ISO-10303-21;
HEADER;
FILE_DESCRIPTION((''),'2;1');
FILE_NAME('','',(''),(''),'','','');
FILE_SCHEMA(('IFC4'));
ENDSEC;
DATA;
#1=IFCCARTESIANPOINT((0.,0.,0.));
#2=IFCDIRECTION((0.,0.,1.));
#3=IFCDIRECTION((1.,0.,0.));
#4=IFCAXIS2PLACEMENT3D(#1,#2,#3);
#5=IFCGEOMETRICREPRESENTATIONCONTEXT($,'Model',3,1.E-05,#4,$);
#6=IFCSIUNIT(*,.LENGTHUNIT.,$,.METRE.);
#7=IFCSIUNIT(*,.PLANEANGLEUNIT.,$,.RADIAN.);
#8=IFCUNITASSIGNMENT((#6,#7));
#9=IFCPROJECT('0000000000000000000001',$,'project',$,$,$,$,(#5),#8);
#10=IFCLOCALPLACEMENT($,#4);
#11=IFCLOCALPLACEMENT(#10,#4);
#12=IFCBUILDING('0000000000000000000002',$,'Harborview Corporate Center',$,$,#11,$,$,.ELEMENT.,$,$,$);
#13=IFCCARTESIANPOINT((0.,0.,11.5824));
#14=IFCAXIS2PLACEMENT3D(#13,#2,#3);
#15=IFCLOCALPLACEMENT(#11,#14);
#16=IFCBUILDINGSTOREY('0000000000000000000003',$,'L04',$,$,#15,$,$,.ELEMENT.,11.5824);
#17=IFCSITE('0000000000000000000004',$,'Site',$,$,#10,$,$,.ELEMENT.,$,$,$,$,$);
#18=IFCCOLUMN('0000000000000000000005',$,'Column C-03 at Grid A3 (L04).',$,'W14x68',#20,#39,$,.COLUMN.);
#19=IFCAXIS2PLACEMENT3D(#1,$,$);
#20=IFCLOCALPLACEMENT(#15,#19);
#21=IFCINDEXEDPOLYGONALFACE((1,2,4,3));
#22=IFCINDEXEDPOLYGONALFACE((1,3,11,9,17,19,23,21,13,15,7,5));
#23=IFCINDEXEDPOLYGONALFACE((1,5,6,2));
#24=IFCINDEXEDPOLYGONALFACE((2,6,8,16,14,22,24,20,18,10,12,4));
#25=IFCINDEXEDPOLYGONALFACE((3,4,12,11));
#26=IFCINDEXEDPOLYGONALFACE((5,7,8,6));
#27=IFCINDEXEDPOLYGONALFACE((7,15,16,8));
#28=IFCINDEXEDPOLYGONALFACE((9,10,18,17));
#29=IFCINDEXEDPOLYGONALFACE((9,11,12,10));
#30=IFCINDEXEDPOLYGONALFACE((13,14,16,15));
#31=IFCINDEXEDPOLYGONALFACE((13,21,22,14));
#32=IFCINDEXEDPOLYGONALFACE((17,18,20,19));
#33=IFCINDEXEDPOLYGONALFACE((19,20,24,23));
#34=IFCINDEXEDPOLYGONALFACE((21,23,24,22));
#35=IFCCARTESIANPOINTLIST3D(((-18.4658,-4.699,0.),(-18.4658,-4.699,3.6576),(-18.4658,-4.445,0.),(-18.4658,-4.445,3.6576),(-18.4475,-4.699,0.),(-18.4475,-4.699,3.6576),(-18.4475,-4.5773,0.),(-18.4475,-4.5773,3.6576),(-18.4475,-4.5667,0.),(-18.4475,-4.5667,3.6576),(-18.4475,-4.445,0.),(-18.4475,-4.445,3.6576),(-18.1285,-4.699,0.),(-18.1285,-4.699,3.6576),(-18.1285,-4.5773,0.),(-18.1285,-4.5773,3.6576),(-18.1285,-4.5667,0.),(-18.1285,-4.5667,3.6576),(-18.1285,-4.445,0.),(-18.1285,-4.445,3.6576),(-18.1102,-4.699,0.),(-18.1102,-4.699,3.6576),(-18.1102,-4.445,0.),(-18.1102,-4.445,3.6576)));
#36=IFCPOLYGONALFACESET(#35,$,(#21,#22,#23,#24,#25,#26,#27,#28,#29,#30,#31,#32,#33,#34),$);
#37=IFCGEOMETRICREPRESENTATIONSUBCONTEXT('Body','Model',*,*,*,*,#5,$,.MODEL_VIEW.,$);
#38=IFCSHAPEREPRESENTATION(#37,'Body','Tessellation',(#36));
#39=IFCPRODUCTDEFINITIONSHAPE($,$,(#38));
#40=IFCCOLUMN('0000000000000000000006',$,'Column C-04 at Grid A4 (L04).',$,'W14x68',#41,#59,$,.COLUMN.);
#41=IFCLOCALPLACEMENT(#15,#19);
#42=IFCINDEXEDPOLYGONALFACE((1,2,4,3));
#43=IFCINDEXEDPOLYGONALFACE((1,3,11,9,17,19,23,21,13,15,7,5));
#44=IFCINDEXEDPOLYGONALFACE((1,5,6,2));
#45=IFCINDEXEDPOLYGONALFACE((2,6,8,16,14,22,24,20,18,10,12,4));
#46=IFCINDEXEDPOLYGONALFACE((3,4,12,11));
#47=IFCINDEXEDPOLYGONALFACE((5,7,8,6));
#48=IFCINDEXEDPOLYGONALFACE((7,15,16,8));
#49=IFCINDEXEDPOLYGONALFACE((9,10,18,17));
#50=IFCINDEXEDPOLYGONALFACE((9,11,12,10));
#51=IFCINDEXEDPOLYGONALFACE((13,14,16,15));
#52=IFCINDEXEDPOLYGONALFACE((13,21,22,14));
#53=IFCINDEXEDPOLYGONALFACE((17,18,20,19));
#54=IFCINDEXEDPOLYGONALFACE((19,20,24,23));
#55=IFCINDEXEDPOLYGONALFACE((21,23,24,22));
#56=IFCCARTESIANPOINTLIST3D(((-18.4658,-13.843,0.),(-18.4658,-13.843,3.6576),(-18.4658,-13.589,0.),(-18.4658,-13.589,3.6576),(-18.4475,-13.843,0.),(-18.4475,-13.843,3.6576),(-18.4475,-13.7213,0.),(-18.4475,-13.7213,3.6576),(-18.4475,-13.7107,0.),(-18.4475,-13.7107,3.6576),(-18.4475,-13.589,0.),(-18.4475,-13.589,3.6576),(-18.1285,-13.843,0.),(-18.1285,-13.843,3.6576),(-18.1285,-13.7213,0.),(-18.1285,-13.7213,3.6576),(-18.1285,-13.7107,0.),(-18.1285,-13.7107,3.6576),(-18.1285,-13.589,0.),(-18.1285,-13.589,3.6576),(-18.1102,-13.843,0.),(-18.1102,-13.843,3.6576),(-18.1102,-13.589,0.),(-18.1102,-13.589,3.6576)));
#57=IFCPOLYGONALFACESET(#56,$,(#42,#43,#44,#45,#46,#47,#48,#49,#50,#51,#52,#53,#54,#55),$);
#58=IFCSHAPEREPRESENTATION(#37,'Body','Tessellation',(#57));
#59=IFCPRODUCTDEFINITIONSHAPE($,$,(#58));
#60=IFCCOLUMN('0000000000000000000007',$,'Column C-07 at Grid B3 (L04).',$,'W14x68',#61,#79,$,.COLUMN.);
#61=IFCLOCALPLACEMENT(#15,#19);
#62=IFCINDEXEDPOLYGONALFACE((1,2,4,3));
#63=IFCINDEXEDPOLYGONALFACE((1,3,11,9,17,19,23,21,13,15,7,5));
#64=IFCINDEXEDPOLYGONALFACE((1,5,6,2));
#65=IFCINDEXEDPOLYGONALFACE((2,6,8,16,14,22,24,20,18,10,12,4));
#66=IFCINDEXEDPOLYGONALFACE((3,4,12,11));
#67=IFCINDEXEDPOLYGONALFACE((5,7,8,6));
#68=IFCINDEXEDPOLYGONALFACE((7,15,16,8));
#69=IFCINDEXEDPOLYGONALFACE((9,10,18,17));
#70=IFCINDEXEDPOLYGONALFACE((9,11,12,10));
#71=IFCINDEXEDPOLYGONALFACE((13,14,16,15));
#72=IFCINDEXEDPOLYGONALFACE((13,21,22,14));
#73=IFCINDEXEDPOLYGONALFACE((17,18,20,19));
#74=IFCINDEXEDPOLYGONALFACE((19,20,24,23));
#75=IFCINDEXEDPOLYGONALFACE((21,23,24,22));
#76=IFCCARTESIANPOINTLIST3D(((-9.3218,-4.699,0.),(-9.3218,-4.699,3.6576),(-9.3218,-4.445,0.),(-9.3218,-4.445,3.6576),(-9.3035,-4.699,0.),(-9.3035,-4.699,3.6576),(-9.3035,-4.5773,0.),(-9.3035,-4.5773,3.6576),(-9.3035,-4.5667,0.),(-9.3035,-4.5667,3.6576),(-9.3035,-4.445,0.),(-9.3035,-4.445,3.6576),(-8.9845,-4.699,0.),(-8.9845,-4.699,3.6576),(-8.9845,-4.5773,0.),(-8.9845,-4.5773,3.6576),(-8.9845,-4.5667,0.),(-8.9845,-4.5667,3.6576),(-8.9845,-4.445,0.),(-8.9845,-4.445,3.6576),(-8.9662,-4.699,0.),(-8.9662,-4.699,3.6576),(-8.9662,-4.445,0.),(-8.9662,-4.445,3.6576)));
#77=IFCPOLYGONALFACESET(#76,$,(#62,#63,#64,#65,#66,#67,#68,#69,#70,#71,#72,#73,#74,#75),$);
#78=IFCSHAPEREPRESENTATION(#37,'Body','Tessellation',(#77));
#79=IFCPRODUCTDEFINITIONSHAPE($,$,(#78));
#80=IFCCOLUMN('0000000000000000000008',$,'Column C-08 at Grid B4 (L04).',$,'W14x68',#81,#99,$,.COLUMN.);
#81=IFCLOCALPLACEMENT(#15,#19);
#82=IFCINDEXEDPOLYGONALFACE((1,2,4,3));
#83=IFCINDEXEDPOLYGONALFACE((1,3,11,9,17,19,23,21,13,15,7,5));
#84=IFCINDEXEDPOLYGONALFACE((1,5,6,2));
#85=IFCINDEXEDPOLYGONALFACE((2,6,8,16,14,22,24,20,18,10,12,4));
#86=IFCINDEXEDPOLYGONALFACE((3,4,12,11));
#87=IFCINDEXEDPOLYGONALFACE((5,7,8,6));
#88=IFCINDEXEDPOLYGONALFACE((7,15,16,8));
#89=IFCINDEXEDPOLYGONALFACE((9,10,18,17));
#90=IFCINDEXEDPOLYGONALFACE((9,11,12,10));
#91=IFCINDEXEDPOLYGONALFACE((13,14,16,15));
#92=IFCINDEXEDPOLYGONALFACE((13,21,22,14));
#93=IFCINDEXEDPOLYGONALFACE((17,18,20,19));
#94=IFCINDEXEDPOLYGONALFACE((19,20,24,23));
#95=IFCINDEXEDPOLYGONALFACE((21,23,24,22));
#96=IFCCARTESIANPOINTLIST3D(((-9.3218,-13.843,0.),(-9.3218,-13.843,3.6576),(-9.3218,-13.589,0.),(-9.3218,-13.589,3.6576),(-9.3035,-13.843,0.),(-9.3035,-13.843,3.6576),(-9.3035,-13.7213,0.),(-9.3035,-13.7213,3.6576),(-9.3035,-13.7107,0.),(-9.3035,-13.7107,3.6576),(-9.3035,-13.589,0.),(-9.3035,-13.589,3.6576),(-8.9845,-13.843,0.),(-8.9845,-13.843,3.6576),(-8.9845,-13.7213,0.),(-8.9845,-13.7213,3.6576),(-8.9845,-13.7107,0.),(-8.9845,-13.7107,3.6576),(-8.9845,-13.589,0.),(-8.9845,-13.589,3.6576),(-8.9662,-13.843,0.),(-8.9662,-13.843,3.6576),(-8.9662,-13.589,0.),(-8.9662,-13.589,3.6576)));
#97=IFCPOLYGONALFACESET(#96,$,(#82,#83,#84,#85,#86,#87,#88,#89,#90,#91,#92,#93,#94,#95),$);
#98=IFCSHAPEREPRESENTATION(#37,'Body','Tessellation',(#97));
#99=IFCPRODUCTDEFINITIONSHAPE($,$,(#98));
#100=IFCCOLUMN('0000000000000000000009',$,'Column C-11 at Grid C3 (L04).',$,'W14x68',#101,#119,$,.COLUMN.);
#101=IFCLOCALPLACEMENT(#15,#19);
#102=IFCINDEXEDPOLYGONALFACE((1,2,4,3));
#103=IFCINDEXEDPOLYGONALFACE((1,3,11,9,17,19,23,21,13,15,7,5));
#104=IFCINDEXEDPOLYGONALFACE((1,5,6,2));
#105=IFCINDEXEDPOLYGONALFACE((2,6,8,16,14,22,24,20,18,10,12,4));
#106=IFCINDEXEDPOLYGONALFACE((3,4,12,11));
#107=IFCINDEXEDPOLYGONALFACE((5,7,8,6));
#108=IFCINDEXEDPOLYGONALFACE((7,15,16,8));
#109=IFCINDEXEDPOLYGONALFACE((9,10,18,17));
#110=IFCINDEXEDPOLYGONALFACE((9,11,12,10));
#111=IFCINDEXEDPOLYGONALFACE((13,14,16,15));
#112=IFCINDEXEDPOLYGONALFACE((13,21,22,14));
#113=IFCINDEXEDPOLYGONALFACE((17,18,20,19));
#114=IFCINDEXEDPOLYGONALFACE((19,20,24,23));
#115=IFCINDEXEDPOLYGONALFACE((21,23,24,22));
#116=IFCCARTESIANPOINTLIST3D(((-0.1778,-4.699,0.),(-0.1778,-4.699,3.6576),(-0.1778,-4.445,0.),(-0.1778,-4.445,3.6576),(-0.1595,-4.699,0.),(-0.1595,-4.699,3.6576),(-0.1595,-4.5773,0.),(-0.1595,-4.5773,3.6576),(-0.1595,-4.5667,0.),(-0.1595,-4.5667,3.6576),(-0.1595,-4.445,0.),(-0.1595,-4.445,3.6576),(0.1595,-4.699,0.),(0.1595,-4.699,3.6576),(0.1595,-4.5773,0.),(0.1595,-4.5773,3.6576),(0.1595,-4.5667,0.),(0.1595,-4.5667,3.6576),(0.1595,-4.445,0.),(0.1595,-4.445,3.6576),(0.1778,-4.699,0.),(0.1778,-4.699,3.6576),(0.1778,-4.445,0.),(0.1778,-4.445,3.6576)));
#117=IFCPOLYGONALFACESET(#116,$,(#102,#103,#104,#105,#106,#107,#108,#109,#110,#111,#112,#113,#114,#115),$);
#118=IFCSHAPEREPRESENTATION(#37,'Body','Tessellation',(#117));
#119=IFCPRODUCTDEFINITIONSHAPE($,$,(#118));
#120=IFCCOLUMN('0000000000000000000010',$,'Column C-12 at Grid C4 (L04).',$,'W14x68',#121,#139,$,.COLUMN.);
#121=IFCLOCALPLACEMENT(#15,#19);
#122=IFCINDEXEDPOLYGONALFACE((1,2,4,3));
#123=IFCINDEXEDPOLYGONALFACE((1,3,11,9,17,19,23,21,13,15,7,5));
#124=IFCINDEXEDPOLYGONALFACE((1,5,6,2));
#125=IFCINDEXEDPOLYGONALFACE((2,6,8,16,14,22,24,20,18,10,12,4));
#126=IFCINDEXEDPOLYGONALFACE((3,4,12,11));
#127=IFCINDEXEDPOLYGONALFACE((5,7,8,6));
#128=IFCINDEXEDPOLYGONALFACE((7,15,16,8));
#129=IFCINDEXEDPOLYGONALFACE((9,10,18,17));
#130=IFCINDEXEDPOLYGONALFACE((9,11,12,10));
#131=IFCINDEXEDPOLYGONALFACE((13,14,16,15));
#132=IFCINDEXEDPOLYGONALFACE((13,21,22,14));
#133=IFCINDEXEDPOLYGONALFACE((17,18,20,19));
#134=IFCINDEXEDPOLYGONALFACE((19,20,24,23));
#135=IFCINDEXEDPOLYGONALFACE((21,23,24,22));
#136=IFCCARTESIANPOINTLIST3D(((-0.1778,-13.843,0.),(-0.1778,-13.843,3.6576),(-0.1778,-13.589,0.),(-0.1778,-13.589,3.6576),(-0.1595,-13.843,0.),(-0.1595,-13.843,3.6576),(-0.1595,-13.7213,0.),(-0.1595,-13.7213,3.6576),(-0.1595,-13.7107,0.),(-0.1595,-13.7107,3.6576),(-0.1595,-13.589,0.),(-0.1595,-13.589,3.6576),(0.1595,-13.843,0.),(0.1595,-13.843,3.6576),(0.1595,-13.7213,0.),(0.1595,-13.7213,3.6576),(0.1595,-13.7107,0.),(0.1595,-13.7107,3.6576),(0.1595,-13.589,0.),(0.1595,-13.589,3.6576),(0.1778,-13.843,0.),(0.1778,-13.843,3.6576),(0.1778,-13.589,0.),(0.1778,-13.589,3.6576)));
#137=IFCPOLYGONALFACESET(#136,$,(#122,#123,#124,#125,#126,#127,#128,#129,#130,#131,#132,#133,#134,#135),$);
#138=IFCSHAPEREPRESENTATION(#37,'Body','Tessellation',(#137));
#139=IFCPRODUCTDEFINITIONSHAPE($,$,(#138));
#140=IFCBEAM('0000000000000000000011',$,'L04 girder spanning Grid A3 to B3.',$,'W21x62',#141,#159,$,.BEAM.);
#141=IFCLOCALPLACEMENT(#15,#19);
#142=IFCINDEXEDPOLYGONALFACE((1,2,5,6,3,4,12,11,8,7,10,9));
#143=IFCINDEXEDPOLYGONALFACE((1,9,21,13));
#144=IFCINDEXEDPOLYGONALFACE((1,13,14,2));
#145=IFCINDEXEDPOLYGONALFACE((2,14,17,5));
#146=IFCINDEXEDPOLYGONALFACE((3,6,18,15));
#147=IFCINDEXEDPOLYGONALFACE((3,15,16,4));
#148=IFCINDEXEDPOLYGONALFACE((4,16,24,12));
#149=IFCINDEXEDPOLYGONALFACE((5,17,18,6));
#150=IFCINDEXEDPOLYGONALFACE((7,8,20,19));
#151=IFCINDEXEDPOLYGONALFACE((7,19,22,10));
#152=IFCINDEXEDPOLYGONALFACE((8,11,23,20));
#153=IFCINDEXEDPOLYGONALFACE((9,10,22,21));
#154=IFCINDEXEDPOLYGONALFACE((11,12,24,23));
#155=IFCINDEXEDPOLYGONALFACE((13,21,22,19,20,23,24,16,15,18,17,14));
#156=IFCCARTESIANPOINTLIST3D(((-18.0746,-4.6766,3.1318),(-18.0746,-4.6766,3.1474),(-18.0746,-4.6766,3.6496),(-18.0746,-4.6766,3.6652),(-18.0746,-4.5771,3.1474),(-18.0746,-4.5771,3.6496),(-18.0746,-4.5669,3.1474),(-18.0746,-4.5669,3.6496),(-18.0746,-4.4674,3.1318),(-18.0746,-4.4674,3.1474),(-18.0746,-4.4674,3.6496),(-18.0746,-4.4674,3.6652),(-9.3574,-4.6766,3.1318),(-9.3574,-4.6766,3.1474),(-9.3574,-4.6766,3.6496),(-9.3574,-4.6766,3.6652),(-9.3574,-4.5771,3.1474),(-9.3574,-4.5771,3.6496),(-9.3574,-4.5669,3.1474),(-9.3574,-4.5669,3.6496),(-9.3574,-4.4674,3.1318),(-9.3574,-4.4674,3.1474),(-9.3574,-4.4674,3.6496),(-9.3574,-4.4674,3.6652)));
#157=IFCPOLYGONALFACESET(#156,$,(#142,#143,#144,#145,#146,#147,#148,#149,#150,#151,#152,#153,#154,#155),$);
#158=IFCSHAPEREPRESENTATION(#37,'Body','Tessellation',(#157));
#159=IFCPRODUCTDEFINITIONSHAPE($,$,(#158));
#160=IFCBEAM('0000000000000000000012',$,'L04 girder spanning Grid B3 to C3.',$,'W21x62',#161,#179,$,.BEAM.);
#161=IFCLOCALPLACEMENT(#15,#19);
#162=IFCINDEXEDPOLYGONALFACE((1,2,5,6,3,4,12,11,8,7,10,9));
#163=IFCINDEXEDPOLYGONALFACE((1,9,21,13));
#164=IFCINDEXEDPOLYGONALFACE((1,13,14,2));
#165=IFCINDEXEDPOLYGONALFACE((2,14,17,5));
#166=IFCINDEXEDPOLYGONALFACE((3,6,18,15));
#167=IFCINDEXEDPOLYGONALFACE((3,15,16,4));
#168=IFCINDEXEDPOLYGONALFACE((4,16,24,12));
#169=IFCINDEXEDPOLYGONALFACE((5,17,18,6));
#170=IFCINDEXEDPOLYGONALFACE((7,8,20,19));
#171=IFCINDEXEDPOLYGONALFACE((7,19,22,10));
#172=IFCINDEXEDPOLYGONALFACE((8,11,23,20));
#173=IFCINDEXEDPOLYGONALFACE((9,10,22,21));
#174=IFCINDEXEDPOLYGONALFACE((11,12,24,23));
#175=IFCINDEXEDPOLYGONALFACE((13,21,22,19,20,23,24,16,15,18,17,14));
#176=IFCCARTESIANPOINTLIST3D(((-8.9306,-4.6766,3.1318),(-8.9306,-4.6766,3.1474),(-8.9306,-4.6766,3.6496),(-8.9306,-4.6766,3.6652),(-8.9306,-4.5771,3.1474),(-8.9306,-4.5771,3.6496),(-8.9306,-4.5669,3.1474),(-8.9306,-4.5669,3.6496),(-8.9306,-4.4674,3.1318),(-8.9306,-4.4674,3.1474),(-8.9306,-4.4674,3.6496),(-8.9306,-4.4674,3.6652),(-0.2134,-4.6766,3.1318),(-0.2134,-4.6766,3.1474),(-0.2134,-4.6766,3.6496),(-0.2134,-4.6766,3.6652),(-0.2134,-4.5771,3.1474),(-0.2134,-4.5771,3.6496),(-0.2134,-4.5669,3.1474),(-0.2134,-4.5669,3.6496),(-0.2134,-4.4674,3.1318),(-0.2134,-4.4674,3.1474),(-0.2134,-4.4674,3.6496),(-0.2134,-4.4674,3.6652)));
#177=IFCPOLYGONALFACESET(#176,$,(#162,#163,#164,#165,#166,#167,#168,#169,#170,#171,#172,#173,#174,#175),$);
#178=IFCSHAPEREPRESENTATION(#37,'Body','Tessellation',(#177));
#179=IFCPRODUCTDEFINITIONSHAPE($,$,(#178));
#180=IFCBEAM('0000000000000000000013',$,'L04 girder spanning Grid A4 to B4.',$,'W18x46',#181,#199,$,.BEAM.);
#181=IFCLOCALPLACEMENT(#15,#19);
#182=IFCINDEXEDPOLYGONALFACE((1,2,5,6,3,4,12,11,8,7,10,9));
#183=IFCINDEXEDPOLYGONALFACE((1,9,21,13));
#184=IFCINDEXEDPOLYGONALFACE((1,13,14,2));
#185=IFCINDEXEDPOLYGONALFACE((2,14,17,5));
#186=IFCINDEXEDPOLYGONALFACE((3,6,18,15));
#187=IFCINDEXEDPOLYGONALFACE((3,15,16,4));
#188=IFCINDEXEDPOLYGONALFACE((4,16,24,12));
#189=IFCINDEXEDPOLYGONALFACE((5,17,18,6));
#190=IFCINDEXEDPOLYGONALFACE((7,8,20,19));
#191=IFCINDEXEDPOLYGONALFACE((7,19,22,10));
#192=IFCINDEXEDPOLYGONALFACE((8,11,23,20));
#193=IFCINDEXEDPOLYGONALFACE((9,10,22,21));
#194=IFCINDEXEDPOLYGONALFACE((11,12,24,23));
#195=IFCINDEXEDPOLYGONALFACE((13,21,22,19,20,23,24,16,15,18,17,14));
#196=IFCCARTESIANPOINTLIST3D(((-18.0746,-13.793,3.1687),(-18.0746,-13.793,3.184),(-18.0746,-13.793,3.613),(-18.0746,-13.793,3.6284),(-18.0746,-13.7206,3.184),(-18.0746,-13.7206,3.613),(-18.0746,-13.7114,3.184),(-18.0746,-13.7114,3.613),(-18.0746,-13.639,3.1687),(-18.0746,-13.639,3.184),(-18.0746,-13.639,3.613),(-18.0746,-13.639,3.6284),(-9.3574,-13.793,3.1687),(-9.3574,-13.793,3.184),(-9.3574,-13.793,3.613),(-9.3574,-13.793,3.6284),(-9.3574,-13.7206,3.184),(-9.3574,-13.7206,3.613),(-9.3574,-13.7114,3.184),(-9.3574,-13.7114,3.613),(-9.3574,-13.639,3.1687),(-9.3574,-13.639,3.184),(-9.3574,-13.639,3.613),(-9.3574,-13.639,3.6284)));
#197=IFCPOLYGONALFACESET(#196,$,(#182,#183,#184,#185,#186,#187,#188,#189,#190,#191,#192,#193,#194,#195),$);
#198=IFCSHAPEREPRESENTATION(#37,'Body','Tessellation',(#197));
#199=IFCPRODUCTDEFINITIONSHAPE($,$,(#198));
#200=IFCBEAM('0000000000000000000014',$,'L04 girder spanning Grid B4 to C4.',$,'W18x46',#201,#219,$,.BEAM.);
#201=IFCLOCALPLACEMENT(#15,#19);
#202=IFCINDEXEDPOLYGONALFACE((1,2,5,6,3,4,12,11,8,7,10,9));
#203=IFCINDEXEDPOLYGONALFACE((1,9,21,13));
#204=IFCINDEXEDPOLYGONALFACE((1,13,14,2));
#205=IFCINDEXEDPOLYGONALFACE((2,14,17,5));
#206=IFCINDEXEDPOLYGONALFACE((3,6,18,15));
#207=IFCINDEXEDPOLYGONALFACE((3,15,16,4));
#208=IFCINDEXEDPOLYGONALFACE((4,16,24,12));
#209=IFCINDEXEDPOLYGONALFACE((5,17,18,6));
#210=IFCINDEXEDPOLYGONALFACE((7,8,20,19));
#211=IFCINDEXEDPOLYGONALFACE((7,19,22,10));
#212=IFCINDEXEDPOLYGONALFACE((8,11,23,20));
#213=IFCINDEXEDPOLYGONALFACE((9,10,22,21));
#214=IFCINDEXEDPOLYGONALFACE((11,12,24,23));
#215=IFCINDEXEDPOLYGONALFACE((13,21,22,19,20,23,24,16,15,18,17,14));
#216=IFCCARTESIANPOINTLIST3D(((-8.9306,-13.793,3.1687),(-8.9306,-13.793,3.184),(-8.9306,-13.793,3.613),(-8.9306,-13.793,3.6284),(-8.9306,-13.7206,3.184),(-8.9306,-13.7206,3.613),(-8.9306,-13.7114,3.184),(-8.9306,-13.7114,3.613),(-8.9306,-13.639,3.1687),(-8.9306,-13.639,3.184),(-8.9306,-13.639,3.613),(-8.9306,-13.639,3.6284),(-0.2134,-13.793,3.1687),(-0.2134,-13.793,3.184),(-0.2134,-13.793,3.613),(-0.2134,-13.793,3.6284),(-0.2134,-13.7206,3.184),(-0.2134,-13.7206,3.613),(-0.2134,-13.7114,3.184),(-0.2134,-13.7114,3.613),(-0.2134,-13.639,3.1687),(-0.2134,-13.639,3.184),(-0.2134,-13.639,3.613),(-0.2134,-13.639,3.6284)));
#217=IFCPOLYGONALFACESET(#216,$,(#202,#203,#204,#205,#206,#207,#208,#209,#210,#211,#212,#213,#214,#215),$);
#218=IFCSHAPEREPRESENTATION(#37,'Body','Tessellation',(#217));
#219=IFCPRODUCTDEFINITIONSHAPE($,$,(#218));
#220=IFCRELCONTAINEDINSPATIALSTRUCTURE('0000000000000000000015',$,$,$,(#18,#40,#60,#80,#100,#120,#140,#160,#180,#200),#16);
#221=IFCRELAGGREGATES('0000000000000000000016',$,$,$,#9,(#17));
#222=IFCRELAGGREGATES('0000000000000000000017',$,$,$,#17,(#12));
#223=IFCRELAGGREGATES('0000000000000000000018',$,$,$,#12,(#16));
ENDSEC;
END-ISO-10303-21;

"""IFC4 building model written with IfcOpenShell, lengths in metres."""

from ifc_helpers import new_model, si_unit, frame, origin_with_axes, place, context, subcontext, project, spatial, i_section, extrude, element, save


model = new_model("IFC4")

# Units and contexts
model_context = context("Model", 3, precision=1e-05, world=origin_with_axes())
body_context = subcontext(model_context, "Body", "Model", "MODEL_VIEW")
ifc_project = project(units=[si_unit("LENGTHUNIT", "METRE"), si_unit("PLANEANGLEUNIT", "RADIAN")], contexts=[model_context])

# Site, building, storey
site_placement = place(None, origin_with_axes())
site = spatial("IfcSite", under=ifc_project, at=site_placement, Name="Site", CompositionType="ELEMENT")
building_placement = place(site_placement, origin_with_axes())
building = spatial("IfcBuilding", under=site, at=building_placement, Name="Harborview Corporate Center", CompositionType="ELEMENT")
storey_placement = place(building_placement, frame((0.0, 0.0, 11.5824), z_axis=(0.0, 0.0, 1.0), x_axis=(1.0, 0.0, 0.0)))
storey = spatial("IfcBuildingStorey", under=building, at=storey_placement, Name="L04", CompositionType="ELEMENT", Elevation=11.5824)

# Columns
for number, where, z_axis, x_axis, name in (
    (1, (-18.288, -4.572, 0.0), (0.0, 0.0, 1.0), (0.0, 1.0, 0.0), "Column C-03 at Grid A3 (L04)."),
    (2, (-18.288, -13.716, 0.0), (0.0, 0.0, 1.0), (0.0, 1.0, 0.0), "Column C-04 at Grid A4 (L04)."),
    (3, (-9.144, -4.572, 0.0), (0.0, 0.0, 1.0), (0.0, 1.0, 0.0), "Column C-07 at Grid B3 (L04)."),
    (4, (-9.144, -13.716, 0.0), (0.0, 0.0, 1.0), (0.0, 1.0, 0.0), "Column C-08 at Grid B4 (L04)."),
    (5, (0.0, -4.572, 0.0), (0.0, 0.0, 1.0), (0.0, 1.0, 0.0), "Column C-11 at Grid C3 (L04)."),
    (6, (0.0, -13.716, 0.0), (0.0, 0.0, 1.0), (0.0, 1.0, 0.0), "Column C-12 at Grid C4 (L04)."),
):
    element("IfcColumn", number, at=place(storey_placement, frame(where, z_axis=z_axis, x_axis=x_axis)), inside=storey, Name=name, ObjectType="W14x68", PredefinedType="COLUMN", context=body_context, shape_type="SweptSolid", body=[
        extrude(i_section(OverallWidth=0.254, OverallDepth=0.3556, WebThickness=0.0105, FlangeThickness=0.0183), origin_with_axes(), (0.0, 0.0, 1.0), 3.6576),
    ])

# Beams
beam_1_placement = place(storey_placement, frame((-18.0746, -4.572, 3.3985), z_axis=(1.0, 0.0, 0.0), x_axis=(0.0, 1.0, 0.0)))
element("IfcBeam", 7, at=beam_1_placement, inside=storey, Name="L04 girder spanning Grid A3 to B3.", ObjectType="W21x62", PredefinedType="BEAM", context=body_context, shape_type="SweptSolid", body=[
    extrude(i_section(OverallWidth=0.2093, OverallDepth=0.5334, WebThickness=0.0102, FlangeThickness=0.0156), origin_with_axes(), (0.0, 0.0, 1.0), 8.7173),
])
beam_2_placement = place(storey_placement, frame((-8.9306, -4.572, 3.3985), z_axis=(1.0, 0.0, 0.0), x_axis=(0.0, 1.0, 0.0)))
element("IfcBeam", 8, at=beam_2_placement, inside=storey, Name="L04 girder spanning Grid B3 to C3.", ObjectType="W21x62", PredefinedType="BEAM", context=body_context, shape_type="SweptSolid", body=[
    extrude(i_section(OverallWidth=0.2093, OverallDepth=0.5334, WebThickness=0.0102, FlangeThickness=0.0156), origin_with_axes(), (0.0, 0.0, 1.0), 8.7173),
])
beam_3_placement = place(storey_placement, frame((-18.0746, -13.716, 3.3985), z_axis=(1.0, 0.0, 0.0), x_axis=(0.0, 1.0, 0.0)))
element("IfcBeam", 9, at=beam_3_placement, inside=storey, Name="L04 girder spanning Grid A4 to B4.", ObjectType="W18x46", PredefinedType="BEAM", context=body_context, shape_type="SweptSolid", body=[
    extrude(i_section(OverallWidth=0.1539, OverallDepth=0.4597, WebThickness=0.0091, FlangeThickness=0.0154), origin_with_axes(), (0.0, 0.0, 1.0), 8.7173),
])
beam_4_placement = place(storey_placement, frame((-8.9306, -13.716, 3.3985), z_axis=(1.0, 0.0, 0.0), x_axis=(0.0, 1.0, 0.0)))
element("IfcBeam", 10, at=beam_4_placement, inside=storey, Name="L04 girder spanning Grid B4 to C4.", ObjectType="W18x46", PredefinedType="BEAM", context=body_context, shape_type="SweptSolid", body=[
    extrude(i_section(OverallWidth=0.1539, OverallDepth=0.4597, WebThickness=0.0091, FlangeThickness=0.0154), origin_with_axes(), (0.0, 0.0, 1.0), 8.7173),
])

save(model, "model.ifc")
